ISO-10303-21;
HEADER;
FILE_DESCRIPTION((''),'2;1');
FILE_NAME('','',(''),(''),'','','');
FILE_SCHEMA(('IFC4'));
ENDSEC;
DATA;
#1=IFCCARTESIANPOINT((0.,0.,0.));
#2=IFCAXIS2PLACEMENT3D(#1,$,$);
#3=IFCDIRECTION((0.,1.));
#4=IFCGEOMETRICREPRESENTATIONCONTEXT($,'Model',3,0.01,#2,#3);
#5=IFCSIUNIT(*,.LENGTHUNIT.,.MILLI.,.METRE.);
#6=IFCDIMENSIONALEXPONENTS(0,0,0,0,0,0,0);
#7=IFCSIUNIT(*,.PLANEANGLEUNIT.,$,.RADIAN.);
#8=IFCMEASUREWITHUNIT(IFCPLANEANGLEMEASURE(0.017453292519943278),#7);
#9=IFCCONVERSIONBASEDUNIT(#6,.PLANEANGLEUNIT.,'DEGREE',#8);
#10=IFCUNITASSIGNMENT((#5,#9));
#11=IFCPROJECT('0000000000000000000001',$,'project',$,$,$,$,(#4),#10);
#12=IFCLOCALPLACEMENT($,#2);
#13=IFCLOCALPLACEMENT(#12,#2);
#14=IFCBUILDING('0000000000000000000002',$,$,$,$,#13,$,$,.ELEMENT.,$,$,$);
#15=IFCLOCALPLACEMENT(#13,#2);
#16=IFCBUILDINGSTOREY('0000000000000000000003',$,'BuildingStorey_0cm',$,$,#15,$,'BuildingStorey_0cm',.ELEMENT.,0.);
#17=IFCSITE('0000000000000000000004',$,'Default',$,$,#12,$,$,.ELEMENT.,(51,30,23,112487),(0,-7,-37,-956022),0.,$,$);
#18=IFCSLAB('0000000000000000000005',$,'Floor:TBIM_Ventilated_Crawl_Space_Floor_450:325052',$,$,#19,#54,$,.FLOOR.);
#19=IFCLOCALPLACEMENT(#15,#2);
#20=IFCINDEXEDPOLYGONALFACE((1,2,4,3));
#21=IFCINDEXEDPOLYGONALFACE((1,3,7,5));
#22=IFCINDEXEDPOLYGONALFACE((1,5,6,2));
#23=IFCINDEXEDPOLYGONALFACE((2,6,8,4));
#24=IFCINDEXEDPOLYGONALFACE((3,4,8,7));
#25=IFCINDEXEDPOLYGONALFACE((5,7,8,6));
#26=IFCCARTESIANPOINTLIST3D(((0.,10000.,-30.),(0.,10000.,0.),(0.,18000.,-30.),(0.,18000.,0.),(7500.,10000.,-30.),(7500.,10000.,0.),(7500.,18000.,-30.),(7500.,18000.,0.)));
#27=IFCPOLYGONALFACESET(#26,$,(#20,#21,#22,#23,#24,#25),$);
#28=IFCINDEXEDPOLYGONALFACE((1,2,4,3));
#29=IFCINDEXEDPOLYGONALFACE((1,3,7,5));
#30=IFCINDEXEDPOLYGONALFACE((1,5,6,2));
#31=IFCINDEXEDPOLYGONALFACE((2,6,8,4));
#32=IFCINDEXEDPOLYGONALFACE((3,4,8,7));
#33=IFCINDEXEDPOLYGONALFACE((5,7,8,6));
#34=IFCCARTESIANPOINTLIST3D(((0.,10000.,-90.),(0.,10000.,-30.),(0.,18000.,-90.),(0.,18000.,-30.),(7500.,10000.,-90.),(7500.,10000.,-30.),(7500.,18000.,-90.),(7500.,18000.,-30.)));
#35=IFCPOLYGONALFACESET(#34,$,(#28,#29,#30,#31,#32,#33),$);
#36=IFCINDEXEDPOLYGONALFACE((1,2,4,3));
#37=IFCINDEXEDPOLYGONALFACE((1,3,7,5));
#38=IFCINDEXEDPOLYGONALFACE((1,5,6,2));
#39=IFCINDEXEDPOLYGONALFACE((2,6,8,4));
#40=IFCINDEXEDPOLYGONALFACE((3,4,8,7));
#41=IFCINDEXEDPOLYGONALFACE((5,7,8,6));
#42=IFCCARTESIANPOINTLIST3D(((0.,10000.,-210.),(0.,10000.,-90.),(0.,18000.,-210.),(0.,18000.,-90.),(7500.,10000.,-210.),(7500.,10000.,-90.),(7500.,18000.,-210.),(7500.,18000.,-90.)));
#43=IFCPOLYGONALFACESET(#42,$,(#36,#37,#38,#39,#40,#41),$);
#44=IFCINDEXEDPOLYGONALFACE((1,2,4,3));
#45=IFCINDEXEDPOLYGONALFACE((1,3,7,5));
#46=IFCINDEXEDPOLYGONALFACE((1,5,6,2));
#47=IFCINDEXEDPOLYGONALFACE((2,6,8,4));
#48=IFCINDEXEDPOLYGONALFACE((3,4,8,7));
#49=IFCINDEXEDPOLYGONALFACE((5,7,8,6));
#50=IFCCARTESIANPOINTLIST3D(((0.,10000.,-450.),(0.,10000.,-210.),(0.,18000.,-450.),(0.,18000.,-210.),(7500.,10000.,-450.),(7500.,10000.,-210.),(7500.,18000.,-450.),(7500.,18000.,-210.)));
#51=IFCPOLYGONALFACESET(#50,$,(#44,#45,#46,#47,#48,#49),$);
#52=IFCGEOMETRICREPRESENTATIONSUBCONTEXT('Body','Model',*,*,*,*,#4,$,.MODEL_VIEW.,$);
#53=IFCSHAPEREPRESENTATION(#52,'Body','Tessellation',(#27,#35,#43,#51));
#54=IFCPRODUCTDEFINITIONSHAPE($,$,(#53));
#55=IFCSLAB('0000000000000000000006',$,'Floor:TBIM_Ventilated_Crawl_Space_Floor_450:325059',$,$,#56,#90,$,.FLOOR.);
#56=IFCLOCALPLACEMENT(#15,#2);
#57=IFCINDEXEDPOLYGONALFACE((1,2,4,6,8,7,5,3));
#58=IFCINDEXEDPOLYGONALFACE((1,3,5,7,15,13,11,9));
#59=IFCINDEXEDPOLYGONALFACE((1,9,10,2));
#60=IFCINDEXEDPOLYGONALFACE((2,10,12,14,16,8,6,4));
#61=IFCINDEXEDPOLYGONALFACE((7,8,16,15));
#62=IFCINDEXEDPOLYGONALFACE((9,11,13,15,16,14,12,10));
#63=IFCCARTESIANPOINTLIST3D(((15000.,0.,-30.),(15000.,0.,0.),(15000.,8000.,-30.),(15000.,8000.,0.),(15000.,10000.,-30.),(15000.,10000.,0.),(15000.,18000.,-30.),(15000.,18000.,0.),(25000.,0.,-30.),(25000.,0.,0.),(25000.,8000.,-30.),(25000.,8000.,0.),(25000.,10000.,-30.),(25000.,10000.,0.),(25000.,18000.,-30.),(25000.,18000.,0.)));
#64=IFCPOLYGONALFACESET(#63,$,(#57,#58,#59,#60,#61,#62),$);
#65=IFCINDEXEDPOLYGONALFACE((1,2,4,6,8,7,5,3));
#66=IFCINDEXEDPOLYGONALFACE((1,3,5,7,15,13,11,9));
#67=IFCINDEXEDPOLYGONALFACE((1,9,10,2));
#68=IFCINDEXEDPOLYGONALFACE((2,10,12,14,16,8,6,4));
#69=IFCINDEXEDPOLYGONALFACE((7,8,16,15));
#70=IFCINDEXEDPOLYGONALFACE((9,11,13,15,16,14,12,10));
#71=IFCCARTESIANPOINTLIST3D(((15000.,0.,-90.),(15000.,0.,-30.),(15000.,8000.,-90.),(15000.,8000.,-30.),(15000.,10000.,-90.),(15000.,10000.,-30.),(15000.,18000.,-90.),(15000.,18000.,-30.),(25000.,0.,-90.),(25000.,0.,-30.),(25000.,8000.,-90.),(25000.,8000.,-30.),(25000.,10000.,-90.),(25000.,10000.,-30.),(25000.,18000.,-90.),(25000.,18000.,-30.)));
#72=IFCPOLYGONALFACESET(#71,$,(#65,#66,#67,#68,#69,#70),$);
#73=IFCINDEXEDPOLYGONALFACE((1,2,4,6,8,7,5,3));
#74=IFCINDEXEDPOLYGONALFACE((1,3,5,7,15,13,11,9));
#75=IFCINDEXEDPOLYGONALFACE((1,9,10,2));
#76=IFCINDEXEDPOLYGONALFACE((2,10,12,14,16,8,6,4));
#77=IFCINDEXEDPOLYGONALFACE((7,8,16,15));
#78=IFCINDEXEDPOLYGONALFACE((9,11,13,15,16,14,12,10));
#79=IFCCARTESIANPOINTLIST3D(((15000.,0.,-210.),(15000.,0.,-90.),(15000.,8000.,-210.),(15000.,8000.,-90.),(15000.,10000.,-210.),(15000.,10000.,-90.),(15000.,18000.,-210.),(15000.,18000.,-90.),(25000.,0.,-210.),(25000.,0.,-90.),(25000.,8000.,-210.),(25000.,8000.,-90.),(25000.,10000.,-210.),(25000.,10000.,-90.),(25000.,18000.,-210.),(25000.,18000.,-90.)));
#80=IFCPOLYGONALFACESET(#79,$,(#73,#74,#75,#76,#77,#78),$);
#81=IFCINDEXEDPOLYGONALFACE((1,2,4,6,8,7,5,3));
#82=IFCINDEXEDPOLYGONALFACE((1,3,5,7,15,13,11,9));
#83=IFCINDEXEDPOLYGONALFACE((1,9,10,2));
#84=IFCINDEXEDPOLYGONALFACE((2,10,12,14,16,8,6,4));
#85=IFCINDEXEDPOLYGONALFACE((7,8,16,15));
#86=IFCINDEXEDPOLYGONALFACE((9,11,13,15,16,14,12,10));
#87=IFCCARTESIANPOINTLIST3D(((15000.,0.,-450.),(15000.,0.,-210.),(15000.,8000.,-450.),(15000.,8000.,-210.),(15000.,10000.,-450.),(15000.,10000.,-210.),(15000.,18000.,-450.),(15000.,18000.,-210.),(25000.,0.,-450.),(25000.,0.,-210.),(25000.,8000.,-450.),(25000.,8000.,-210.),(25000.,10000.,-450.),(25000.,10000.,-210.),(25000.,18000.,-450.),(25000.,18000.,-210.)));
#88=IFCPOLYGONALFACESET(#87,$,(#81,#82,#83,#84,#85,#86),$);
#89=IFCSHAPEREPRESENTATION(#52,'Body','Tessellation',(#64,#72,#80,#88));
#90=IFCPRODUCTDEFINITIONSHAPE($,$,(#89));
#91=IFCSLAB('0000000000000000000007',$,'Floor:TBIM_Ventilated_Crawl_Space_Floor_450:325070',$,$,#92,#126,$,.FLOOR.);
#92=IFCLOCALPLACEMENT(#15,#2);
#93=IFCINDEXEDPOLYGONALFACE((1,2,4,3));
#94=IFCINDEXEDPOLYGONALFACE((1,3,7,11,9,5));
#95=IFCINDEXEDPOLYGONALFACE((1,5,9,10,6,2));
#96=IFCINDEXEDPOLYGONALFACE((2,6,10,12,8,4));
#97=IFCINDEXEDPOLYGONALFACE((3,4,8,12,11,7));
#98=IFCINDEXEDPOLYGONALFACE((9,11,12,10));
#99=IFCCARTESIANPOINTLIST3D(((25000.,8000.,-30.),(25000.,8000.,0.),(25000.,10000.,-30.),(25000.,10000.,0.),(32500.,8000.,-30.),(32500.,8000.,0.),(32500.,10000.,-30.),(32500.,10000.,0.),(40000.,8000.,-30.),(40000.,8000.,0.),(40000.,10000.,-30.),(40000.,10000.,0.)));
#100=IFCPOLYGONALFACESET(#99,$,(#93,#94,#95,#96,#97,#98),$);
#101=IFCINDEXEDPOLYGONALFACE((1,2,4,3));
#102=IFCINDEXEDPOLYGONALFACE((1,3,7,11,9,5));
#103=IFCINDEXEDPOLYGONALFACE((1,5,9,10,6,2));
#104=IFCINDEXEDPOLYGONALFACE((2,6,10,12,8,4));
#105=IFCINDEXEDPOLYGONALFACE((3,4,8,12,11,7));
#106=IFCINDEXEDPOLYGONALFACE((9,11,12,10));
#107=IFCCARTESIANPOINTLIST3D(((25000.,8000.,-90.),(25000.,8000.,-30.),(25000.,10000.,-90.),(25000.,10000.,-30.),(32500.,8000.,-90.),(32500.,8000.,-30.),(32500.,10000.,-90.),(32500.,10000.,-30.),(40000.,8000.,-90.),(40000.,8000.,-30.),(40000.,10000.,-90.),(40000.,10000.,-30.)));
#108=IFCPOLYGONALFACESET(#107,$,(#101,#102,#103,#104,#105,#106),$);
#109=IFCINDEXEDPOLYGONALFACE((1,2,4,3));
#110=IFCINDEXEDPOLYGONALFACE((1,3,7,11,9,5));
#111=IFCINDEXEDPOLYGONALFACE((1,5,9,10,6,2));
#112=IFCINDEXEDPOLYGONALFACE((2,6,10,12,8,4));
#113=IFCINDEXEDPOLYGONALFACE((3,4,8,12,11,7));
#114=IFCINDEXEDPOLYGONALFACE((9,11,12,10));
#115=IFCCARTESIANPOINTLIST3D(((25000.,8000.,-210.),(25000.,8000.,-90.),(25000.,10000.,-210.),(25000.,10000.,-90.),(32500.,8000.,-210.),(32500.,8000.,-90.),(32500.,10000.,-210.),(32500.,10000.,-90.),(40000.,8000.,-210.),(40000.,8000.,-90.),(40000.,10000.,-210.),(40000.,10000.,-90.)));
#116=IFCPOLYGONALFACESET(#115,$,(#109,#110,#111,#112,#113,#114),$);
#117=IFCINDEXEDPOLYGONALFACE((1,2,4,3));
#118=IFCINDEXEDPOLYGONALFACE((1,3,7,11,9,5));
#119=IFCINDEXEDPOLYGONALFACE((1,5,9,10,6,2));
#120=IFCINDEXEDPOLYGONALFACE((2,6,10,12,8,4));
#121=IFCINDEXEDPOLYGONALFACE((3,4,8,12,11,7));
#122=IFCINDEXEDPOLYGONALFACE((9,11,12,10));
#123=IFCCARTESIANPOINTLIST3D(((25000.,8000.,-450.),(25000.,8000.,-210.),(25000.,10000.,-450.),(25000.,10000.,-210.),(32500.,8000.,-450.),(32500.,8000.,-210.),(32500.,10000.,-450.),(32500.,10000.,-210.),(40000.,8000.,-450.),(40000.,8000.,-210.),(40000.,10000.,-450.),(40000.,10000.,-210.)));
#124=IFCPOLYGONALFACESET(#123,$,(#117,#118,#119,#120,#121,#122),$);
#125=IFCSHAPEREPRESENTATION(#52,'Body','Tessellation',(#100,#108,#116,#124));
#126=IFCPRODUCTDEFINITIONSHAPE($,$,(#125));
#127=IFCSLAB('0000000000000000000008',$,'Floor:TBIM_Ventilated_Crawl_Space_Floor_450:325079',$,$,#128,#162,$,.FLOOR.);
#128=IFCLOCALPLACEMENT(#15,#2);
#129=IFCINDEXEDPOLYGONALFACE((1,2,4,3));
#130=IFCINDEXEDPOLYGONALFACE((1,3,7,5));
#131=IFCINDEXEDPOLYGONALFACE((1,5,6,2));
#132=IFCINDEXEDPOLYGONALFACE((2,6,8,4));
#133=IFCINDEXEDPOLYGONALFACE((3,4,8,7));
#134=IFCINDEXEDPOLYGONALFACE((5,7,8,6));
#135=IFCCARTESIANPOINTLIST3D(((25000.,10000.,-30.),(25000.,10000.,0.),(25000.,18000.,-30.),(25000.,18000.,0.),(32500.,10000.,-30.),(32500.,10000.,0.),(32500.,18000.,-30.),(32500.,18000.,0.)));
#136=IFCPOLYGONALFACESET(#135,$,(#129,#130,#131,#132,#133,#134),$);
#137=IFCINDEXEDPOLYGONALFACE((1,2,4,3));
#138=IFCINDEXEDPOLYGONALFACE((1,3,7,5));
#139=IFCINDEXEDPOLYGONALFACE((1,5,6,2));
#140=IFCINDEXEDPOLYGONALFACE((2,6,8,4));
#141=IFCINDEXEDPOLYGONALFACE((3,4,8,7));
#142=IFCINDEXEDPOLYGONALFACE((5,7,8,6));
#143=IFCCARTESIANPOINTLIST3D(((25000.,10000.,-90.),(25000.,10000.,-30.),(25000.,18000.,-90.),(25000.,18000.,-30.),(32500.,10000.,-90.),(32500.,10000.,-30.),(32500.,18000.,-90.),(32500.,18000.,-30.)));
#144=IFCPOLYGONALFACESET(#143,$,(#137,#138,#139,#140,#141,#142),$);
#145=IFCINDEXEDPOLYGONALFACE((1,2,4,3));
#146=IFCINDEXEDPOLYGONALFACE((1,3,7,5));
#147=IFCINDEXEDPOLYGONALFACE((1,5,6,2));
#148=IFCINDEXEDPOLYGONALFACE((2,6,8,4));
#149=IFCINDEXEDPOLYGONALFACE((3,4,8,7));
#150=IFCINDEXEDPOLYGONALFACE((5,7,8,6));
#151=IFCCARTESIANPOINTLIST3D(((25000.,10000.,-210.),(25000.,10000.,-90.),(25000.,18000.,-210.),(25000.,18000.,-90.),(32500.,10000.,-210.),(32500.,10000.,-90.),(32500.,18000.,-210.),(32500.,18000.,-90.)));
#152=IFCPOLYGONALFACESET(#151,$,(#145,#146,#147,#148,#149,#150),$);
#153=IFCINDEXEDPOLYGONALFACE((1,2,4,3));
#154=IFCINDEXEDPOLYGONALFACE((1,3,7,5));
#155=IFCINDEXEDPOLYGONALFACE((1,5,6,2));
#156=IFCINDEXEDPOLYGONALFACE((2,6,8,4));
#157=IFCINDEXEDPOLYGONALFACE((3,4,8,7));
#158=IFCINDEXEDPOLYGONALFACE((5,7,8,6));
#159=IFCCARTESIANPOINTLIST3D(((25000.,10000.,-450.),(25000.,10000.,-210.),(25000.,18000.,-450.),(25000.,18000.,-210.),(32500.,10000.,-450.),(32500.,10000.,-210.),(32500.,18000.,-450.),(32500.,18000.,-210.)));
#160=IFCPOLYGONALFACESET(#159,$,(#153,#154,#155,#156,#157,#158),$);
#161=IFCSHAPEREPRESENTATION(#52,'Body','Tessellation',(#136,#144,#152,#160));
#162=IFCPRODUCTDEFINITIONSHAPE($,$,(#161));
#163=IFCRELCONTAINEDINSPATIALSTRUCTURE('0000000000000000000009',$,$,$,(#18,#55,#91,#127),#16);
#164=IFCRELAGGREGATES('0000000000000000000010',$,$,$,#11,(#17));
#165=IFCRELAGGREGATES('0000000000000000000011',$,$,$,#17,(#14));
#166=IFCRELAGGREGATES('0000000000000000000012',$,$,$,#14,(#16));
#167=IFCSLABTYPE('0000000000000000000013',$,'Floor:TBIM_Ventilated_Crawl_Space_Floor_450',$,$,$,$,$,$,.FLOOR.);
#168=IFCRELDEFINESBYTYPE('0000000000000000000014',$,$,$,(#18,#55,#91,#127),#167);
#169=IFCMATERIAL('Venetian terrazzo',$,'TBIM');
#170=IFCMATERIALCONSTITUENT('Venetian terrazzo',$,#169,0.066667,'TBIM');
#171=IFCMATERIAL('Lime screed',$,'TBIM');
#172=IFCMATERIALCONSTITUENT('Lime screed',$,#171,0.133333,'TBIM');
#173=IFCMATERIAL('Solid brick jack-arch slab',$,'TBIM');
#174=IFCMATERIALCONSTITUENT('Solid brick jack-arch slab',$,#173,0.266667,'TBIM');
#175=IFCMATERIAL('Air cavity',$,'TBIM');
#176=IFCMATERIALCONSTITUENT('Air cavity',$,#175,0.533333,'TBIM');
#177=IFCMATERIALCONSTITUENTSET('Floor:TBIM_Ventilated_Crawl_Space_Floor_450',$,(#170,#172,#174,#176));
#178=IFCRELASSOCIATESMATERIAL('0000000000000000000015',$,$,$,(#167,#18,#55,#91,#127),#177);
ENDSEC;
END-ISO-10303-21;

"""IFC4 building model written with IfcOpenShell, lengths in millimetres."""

from ifc_helpers import new_model, entity, si_unit, converted_unit, direction, frame, origin, place, context, subcontext, project, spatial, indexed_curve, outline, extrude, material, constituent, constituent_set, type_object, element, save


model = new_model("IFC4")

# Units and contexts
model_context = context("Model", 3, precision=0.01, world=origin(), true_north=direction((0.0, 1.0)))
body_context = subcontext(model_context, "Body", "Model", "MODEL_VIEW")
ifc_project = project(units=[si_unit("LENGTHUNIT", "METRE", prefix="MILLI"), converted_unit("PLANEANGLEUNIT", "DEGREE", entity("IfcPlaneAngleMeasure", 0.017453292519943278), si_unit("PLANEANGLEUNIT", "RADIAN"), dimensions=[0, 0, 0, 0, 0, 0, 0])], contexts=[model_context])

# Site, building, storey
site_placement = place(None, origin())
site = spatial("IfcSite", under=ifc_project, at=site_placement, Name="Default", CompositionType="ELEMENT", RefLatitude=(51, 30, 23, 112487), RefLongitude=(0, -7, -37, -956022), RefElevation=0.0)
building_placement = place(site_placement, origin())
building = spatial("IfcBuilding", under=site, at=building_placement, CompositionType="ELEMENT")
storey_placement = place(building_placement, origin())
storey = spatial("IfcBuildingStorey", under=building, at=storey_placement, Name="BuildingStorey_0cm", LongName="BuildingStorey_0cm", CompositionType="ELEMENT", Elevation=0.0)

# Slabs
ifc_material_1 = material(Name="Venetian terrazzo", Category="TBIM")
ifc_constituent_1 = constituent(ifc_material_1, Name="Venetian terrazzo", Category="TBIM", fraction=0.066667)
ifc_material_2 = material(Name="Lime screed", Category="TBIM")
ifc_constituent_2 = constituent(ifc_material_2, Name="Lime screed", Category="TBIM", fraction=0.133333)
ifc_material_3 = material(Name="Solid brick jack-arch slab", Category="TBIM")
ifc_constituent_3 = constituent(ifc_material_3, Name="Solid brick jack-arch slab", Category="TBIM", fraction=0.266667)
ifc_material_4 = material(Name="Air cavity", Category="TBIM")
ifc_constituent_4 = constituent(ifc_material_4, Name="Air cavity", Category="TBIM", fraction=0.533333)
ifc_constituent_set_1 = constituent_set(constituents=[ifc_constituent_1, ifc_constituent_2, ifc_constituent_3, ifc_constituent_4], Name="Floor:TBIM_Ventilated_Crawl_Space_Floor_450")
slab_type = type_object("IfcSlabType", Name="Floor:TBIM_Ventilated_Crawl_Space_Floor_450", PredefinedType="FLOOR", material=ifc_constituent_set_1)
slab_1_placement = place(storey_placement, origin())
element("IfcSlab", 1, at=slab_1_placement, inside=storey, type_object=slab_type, material=ifc_constituent_set_1, Name="Floor:TBIM_Ventilated_Crawl_Space_Floor_450:325052", PredefinedType="FLOOR", context=body_context, shape_type="SweptSolid", body=[
    extrude(outline(indexed_curve([(-3750.0, -4000.0), (3750.0, -4000.0), (3750.0, 4000.0), (-3750.0, 4000.0), (-3750.0, -4000.0)], self_intersect=False)), frame((3750.0, 14000.0, -30.0), z_axis=(0.0, 0.0, 1.0), x_axis=(-1.0, 0.0, 0.0)), (0.0, 0.0, 1.0), 30.0),
    extrude(outline(indexed_curve([(-3750.0, -4000.0), (3750.0, -4000.0), (3750.0, 4000.0), (-3750.0, 4000.0), (-3750.0, -4000.0)], self_intersect=False)), frame((3750.0, 14000.0, -90.0), z_axis=(0.0, 0.0, 1.0), x_axis=(-1.0, 0.0, 0.0)), (0.0, 0.0, 1.0), 60.0),
    extrude(outline(indexed_curve([(-3750.0, -4000.0), (3750.0, -4000.0), (3750.0, 4000.0), (-3750.0, 4000.0), (-3750.0, -4000.0)], self_intersect=False)), frame((3750.0, 14000.0, -210.0), z_axis=(0.0, 0.0, 1.0), x_axis=(-1.0, 0.0, 0.0)), (0.0, 0.0, 1.0), 120.0),
    extrude(outline(indexed_curve([(-3750.0, -4000.0), (3750.0, -4000.0), (3750.0, 4000.0), (-3750.0, 4000.0), (-3750.0, -4000.0)], self_intersect=False)), frame((3750.0, 14000.0, -450.0), z_axis=(0.0, 0.0, 1.0), x_axis=(-1.0, 0.0, 0.0)), (0.0, 0.0, 1.0), 240.0),
])
slab_2_placement = place(storey_placement, origin())
element("IfcSlab", 2, at=slab_2_placement, inside=storey, type_object=slab_type, material=ifc_constituent_set_1, Name="Floor:TBIM_Ventilated_Crawl_Space_Floor_450:325059", PredefinedType="FLOOR", context=body_context, shape_type="SweptSolid", body=[
    extrude(outline(indexed_curve([(-5000.0, -9000.0), (5000.0, -9000.0), (5000.0, -1000.0), (5000.0, 1000.0), (5000.0, 9000.0), (-5000.0, 9000.0), (-5000.0, 1000.0), (-5000.0, -1000.0), (-5000.0, -9000.0)], self_intersect=False)), frame((20000.0, 9000.0, -30.0), z_axis=(0.0, 0.0, 1.0), x_axis=(-1.0, 0.0, 0.0)), (0.0, 0.0, 1.0), 30.0),
    extrude(outline(indexed_curve([(-5000.0, -9000.0), (5000.0, -9000.0), (5000.0, -1000.0), (5000.0, 1000.0), (5000.0, 9000.0), (-5000.0, 9000.0), (-5000.0, 1000.0), (-5000.0, -1000.0), (-5000.0, -9000.0)], self_intersect=False)), frame((20000.0, 9000.0, -90.0), z_axis=(0.0, 0.0, 1.0), x_axis=(-1.0, 0.0, 0.0)), (0.0, 0.0, 1.0), 60.0),
    extrude(outline(indexed_curve([(-5000.0, -9000.0), (5000.0, -9000.0), (5000.0, -1000.0), (5000.0, 1000.0), (5000.0, 9000.0), (-5000.0, 9000.0), (-5000.0, 1000.0), (-5000.0, -1000.0), (-5000.0, -9000.0)], self_intersect=False)), frame((20000.0, 9000.0, -210.0), z_axis=(0.0, 0.0, 1.0), x_axis=(-1.0, 0.0, 0.0)), (0.0, 0.0, 1.0), 120.0),
    extrude(outline(indexed_curve([(-5000.0, -9000.0), (5000.0, -9000.0), (5000.0, -1000.0), (5000.0, 1000.0), (5000.0, 9000.0), (-5000.0, 9000.0), (-5000.0, 1000.0), (-5000.0, -1000.0), (-5000.0, -9000.0)], self_intersect=False)), frame((20000.0, 9000.0, -450.0), z_axis=(0.0, 0.0, 1.0), x_axis=(-1.0, 0.0, 0.0)), (0.0, 0.0, 1.0), 240.0),
])
slab_3_placement = place(storey_placement, origin())
element("IfcSlab", 3, at=slab_3_placement, inside=storey, type_object=slab_type, material=ifc_constituent_set_1, Name="Floor:TBIM_Ventilated_Crawl_Space_Floor_450:325070", PredefinedType="FLOOR", context=body_context, shape_type="SweptSolid", body=[
    extrude(outline(indexed_curve([(-7500.0, -1000.0), (0.0, -1000.0), (7500.0, -1000.0), (7500.0, 1000.0), (0.0, 1000.0), (-7500.0, 1000.0), (-7500.0, -1000.0)], self_intersect=False)), frame((32500.0, 9000.0, -30.0), z_axis=(0.0, 0.0, 1.0), x_axis=(-1.0, 0.0, 0.0)), (0.0, 0.0, 1.0), 30.0),
    extrude(outline(indexed_curve([(-7500.0, -1000.0), (0.0, -1000.0), (7500.0, -1000.0), (7500.0, 1000.0), (0.0, 1000.0), (-7500.0, 1000.0), (-7500.0, -1000.0)], self_intersect=False)), frame((32500.0, 9000.0, -90.0), z_axis=(0.0, 0.0, 1.0), x_axis=(-1.0, 0.0, 0.0)), (0.0, 0.0, 1.0), 60.0),
    extrude(outline(indexed_curve([(-7500.0, -1000.0), (0.0, -1000.0), (7500.0, -1000.0), (7500.0, 1000.0), (0.0, 1000.0), (-7500.0, 1000.0), (-7500.0, -1000.0)], self_intersect=False)), frame((32500.0, 9000.0, -210.0), z_axis=(0.0, 0.0, 1.0), x_axis=(-1.0, 0.0, 0.0)), (0.0, 0.0, 1.0), 120.0),
    extrude(outline(indexed_curve([(-7500.0, -1000.0), (0.0, -1000.0), (7500.0, -1000.0), (7500.0, 1000.0), (0.0, 1000.0), (-7500.0, 1000.0), (-7500.0, -1000.0)], self_intersect=False)), frame((32500.0, 9000.0, -450.0), z_axis=(0.0, 0.0, 1.0), x_axis=(-1.0, 0.0, 0.0)), (0.0, 0.0, 1.0), 240.0),
])
slab_4_placement = place(storey_placement, origin())
element("IfcSlab", 4, at=slab_4_placement, inside=storey, type_object=slab_type, material=ifc_constituent_set_1, Name="Floor:TBIM_Ventilated_Crawl_Space_Floor_450:325079", PredefinedType="FLOOR", context=body_context, shape_type="SweptSolid", body=[
    extrude(outline(indexed_curve([(-3750.0, -4000.0), (3750.0, -4000.0), (3750.0, 4000.0), (-3750.0, 4000.0), (-3750.0, -4000.0)], self_intersect=False)), frame((28750.0, 14000.0, -30.0), z_axis=(0.0, 0.0, 1.0), x_axis=(-1.0, 0.0, 0.0)), (0.0, 0.0, 1.0), 30.0),
    extrude(outline(indexed_curve([(-3750.0, -4000.0), (3750.0, -4000.0), (3750.0, 4000.0), (-3750.0, 4000.0), (-3750.0, -4000.0)], self_intersect=False)), frame((28750.0, 14000.0, -90.0), z_axis=(0.0, 0.0, 1.0), x_axis=(-1.0, 0.0, 0.0)), (0.0, 0.0, 1.0), 60.0),
    extrude(outline(indexed_curve([(-3750.0, -4000.0), (3750.0, -4000.0), (3750.0, 4000.0), (-3750.0, 4000.0), (-3750.0, -4000.0)], self_intersect=False)), frame((28750.0, 14000.0, -210.0), z_axis=(0.0, 0.0, 1.0), x_axis=(-1.0, 0.0, 0.0)), (0.0, 0.0, 1.0), 120.0),
    extrude(outline(indexed_curve([(-3750.0, -4000.0), (3750.0, -4000.0), (3750.0, 4000.0), (-3750.0, 4000.0), (-3750.0, -4000.0)], self_intersect=False)), frame((28750.0, 14000.0, -450.0), z_axis=(0.0, 0.0, 1.0), x_axis=(-1.0, 0.0, 0.0)), (0.0, 0.0, 1.0), 240.0),
])

save(model, "model.ifc")
